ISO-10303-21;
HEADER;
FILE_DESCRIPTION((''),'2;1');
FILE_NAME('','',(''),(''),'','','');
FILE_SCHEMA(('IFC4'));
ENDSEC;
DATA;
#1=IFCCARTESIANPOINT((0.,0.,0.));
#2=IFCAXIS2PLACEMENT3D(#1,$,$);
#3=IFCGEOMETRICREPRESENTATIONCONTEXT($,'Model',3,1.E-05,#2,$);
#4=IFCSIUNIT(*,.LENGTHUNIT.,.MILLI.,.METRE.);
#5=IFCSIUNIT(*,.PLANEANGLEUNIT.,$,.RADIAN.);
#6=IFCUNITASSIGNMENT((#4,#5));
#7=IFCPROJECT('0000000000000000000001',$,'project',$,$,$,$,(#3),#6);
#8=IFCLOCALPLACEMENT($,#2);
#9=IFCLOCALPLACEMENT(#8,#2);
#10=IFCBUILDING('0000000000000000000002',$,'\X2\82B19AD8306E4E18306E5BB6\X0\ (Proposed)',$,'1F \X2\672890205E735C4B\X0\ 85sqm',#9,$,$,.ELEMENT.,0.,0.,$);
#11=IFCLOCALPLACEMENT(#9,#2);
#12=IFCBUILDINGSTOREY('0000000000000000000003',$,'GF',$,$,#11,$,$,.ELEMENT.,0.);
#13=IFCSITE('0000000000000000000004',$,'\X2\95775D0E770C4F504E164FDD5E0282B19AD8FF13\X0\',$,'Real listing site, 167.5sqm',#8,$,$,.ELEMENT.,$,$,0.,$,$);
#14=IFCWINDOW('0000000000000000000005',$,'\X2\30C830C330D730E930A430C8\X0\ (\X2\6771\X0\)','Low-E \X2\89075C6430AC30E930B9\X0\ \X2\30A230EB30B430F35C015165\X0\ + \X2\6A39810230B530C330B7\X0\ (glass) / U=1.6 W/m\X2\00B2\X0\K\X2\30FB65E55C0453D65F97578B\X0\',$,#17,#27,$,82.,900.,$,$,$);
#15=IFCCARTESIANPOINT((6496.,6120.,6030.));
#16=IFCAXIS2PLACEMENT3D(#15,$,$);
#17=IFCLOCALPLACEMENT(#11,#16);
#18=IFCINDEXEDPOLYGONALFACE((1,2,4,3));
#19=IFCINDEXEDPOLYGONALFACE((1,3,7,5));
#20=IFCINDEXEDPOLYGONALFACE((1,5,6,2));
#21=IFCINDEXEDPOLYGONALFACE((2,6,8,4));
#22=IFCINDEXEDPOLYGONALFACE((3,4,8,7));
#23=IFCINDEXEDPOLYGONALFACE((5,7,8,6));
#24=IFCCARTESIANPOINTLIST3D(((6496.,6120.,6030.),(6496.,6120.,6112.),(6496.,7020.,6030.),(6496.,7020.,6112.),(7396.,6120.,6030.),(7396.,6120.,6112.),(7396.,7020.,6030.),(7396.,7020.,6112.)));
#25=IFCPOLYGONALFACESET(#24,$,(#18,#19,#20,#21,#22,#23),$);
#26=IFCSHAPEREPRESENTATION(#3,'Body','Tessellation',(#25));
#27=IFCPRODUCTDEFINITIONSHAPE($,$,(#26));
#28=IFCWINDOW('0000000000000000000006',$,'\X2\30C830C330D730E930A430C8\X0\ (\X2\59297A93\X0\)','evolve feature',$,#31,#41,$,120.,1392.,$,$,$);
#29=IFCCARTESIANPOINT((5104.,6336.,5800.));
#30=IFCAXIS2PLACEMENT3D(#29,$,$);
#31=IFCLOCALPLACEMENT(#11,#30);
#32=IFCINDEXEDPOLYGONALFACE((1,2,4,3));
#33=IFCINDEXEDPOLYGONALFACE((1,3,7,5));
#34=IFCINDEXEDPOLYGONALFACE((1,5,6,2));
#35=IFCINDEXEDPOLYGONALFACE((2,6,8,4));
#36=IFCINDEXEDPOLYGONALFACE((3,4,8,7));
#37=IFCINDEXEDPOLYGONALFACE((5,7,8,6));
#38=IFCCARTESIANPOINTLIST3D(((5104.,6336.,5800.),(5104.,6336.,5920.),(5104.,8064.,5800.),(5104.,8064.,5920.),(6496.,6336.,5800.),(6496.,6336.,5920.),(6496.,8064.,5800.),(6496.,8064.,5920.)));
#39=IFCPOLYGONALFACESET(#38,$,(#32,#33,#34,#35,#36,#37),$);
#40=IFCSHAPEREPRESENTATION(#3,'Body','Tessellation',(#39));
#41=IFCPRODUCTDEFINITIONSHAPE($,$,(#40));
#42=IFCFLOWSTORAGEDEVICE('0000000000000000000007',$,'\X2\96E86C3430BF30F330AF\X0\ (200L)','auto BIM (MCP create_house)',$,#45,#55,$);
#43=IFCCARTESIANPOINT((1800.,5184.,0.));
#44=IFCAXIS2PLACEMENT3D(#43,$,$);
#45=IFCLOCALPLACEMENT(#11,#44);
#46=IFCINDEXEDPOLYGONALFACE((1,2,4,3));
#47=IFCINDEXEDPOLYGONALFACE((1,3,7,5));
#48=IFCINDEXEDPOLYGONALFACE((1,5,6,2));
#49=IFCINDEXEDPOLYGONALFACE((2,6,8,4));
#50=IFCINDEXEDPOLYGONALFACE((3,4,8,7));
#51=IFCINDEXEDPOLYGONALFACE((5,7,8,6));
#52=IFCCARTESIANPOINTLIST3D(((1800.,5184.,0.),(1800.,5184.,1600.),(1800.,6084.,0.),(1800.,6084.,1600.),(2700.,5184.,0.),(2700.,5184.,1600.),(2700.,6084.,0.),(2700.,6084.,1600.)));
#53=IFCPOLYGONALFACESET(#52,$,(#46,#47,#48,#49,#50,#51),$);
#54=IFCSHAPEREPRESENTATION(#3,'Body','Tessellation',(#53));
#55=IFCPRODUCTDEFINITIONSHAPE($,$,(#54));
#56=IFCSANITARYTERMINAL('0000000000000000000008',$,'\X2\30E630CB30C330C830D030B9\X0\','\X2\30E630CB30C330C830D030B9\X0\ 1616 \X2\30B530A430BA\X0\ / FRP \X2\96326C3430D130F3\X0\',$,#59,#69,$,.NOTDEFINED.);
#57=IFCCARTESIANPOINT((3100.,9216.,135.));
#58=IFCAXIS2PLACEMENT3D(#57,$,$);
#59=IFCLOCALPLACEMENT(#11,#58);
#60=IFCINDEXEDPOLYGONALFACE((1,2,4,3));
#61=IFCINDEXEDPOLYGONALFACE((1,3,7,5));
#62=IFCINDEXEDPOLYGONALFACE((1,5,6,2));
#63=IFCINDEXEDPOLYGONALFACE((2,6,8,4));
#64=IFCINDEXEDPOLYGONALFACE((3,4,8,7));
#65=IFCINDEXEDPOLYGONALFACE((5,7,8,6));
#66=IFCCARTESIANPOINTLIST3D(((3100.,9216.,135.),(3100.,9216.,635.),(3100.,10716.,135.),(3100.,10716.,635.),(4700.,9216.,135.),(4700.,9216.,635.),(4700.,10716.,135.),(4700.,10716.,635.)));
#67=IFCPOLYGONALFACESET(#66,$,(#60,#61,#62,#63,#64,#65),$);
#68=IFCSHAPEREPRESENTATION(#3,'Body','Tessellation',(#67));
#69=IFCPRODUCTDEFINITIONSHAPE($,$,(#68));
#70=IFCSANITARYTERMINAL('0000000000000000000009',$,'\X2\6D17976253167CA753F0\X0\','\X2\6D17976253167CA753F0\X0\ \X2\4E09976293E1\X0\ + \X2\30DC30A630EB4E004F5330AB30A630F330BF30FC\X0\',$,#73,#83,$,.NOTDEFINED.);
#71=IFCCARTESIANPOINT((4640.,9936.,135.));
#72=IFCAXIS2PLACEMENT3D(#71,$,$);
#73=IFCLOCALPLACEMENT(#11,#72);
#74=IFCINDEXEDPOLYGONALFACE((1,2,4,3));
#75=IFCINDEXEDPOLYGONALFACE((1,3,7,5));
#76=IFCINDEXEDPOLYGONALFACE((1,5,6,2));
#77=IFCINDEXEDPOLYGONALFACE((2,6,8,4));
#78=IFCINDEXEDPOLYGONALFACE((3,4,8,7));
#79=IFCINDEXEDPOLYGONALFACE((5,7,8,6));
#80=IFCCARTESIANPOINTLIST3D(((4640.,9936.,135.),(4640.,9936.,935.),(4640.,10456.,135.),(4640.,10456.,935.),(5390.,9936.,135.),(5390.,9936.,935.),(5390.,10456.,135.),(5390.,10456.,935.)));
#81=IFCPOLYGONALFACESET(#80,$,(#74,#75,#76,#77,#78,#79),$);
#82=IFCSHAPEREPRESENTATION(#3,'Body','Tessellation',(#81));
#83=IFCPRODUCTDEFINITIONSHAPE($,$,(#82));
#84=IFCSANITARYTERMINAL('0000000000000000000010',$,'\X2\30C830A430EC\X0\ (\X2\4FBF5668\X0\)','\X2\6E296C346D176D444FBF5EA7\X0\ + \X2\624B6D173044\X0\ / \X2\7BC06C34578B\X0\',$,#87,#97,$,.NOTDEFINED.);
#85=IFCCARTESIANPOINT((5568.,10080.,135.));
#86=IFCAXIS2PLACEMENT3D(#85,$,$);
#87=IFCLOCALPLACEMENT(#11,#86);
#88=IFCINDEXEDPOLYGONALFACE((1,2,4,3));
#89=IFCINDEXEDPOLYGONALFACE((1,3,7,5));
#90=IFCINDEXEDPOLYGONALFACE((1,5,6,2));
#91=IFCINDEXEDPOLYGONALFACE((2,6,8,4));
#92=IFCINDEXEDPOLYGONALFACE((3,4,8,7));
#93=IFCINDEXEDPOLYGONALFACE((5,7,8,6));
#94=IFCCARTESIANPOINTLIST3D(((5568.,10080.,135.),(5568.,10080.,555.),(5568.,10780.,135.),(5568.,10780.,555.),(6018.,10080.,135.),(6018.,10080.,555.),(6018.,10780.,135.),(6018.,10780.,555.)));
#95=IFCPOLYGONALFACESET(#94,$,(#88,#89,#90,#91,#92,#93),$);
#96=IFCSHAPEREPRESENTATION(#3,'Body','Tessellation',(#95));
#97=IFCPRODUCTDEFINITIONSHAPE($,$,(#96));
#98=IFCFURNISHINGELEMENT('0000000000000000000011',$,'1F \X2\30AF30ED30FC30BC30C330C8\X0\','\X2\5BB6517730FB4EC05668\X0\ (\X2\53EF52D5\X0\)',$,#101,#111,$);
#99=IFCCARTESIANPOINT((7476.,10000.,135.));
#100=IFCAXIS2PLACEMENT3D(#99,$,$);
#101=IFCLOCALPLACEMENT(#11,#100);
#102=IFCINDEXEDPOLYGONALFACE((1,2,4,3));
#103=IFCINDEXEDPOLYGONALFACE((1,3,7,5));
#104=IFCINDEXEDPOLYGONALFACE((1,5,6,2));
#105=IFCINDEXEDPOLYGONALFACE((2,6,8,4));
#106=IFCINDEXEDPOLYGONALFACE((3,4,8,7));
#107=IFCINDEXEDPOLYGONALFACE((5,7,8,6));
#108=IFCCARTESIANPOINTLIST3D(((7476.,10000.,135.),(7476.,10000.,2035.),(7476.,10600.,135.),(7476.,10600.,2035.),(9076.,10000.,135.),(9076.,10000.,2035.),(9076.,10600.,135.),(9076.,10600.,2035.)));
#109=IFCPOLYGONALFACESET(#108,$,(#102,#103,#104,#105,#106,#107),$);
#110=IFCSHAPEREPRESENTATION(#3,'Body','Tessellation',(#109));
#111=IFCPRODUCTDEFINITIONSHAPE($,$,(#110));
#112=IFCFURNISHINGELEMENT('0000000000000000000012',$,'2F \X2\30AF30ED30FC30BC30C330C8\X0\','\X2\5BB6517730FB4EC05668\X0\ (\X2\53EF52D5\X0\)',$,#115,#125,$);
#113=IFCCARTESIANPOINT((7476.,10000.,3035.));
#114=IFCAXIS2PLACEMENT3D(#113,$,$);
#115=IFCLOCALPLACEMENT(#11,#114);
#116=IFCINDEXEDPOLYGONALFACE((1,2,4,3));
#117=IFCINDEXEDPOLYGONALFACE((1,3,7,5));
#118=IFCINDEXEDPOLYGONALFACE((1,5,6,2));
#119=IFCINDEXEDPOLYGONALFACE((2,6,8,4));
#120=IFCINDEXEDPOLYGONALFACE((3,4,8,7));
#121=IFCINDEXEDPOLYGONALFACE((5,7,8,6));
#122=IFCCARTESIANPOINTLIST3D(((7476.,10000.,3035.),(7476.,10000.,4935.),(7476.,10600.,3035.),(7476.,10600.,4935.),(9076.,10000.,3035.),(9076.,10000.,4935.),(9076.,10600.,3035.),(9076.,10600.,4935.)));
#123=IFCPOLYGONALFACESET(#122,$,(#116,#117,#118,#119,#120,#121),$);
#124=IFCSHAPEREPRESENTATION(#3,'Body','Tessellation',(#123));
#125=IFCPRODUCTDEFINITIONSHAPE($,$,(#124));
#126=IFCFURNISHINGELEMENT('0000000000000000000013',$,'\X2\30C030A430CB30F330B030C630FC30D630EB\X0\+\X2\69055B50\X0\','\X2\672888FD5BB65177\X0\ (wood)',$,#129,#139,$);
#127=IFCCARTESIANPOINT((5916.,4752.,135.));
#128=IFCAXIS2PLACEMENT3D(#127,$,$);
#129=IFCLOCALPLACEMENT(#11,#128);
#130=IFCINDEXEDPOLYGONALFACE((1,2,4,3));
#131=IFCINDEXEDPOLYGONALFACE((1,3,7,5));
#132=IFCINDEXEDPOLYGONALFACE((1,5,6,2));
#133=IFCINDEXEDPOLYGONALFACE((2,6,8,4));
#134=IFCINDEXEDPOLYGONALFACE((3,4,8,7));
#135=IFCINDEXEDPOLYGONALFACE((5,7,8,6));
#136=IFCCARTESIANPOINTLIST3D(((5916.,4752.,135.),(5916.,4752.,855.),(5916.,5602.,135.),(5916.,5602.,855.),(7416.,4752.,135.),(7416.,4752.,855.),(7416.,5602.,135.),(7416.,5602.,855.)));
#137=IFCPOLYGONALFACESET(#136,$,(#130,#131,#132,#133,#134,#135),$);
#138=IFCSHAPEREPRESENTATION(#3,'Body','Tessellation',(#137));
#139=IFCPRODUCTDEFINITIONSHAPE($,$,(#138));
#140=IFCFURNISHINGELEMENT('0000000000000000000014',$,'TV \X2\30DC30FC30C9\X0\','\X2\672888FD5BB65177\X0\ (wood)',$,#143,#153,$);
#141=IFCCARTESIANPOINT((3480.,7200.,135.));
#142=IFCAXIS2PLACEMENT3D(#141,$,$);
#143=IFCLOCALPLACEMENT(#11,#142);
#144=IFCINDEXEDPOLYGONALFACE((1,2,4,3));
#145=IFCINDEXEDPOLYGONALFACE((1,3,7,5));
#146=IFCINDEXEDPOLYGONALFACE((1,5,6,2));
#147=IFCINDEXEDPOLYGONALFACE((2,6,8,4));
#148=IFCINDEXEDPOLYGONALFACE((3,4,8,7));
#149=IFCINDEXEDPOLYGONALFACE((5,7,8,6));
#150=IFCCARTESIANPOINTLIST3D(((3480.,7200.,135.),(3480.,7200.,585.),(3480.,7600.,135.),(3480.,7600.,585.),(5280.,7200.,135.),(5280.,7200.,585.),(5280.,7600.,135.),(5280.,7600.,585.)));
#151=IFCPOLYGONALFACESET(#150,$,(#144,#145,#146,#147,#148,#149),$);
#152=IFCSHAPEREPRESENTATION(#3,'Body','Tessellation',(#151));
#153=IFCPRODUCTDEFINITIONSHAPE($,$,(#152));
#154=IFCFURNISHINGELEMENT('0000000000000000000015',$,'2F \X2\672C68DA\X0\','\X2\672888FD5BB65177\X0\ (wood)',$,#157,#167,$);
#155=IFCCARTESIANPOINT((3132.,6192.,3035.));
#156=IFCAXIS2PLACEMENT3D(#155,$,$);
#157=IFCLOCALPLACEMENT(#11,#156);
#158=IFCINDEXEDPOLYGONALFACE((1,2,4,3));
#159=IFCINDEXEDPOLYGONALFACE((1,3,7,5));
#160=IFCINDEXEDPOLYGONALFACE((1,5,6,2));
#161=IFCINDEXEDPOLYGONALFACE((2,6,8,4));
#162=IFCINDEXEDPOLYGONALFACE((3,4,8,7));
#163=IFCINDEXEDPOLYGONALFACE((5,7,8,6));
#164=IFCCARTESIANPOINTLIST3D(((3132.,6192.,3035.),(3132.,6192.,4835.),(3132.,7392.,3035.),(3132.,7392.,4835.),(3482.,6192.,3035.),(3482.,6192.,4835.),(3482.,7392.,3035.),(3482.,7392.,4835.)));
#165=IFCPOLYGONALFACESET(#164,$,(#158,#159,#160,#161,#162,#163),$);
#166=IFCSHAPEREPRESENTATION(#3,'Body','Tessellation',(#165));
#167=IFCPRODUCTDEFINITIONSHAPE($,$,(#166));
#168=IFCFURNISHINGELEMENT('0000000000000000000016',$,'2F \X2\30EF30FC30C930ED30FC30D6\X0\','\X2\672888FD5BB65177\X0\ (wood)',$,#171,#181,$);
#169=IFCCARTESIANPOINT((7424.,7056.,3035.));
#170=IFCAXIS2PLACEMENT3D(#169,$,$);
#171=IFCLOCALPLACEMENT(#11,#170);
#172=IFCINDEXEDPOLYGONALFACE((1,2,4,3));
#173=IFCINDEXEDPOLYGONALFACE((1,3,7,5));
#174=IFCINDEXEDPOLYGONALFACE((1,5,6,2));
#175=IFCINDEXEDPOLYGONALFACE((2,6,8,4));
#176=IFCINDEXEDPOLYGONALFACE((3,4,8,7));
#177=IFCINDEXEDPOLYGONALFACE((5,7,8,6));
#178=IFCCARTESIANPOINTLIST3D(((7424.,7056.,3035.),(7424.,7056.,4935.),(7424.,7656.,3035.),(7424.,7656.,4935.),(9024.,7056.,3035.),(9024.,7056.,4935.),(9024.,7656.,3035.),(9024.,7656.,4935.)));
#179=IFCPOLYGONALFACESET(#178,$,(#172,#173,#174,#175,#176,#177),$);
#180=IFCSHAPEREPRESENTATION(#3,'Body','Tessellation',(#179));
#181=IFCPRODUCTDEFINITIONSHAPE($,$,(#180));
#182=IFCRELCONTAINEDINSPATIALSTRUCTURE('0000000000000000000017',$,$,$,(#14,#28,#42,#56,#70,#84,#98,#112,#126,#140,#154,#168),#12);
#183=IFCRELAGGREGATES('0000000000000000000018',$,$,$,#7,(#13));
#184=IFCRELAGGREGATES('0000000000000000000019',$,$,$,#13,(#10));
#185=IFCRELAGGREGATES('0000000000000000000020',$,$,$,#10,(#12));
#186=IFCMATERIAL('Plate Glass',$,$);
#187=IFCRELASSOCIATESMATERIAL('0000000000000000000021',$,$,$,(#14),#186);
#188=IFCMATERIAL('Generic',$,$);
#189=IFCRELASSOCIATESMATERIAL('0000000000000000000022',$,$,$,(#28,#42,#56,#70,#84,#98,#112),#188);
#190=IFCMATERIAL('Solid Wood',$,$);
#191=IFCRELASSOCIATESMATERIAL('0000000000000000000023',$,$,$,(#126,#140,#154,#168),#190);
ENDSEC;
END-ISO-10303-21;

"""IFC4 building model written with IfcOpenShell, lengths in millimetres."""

from ifc_helpers import new_model, si_unit, frame, frame_2d, origin, place, context, project, spatial, rectangle, extrude, material, element, save


model = new_model("IFC4")

# Units and contexts
model_context = context("Model", 3, precision=1e-05, world=origin())
ifc_project = project(units=[si_unit("LENGTHUNIT", "METRE", prefix="MILLI"), si_unit("PLANEANGLEUNIT", "RADIAN")], contexts=[model_context])

# Site, building, storey
site_placement = place(None, origin())
site = spatial("IfcSite", under=ifc_project, at=site_placement, Name="長崎県佐世保市花高３", ObjectType="Real listing site, 167.5sqm", CompositionType="ELEMENT", RefElevation=0.0)
building_placement = place(site_placement, origin())
building = spatial("IfcBuilding", under=site, at=building_placement, Name="花高の丘の家 (Proposed)", ObjectType="1F 木造平屋 85sqm", CompositionType="ELEMENT", ElevationOfRefHeight=0.0, ElevationOfTerrain=0.0)
storey_placement = place(building_placement, origin())
storey = spatial("IfcBuildingStorey", under=building, at=storey_placement, Name="GF", CompositionType="ELEMENT", Elevation=0.0)

# Shared definitions
ifc_material_1 = material(Name="Solid Wood")
ifc_material_2 = material(Name="Plate Glass")

# Windows
window_1_placement = place(storey_placement, frame((6496.0, 6120.0, 6030.0)))
element("IfcWindow", 1, at=window_1_placement, inside=storey, material=ifc_material_2, Name="トップライト (東)", Description="Low-E 複層ガラス アルゴン封入 + 樹脂サッシ (glass) / U=1.6 W/m²K・日射取得型", OverallHeight=82.0, OverallWidth=900.0, context=model_context, shape_type="SweptSolid", body=[
    extrude(rectangle(XDim=900.0, YDim=900.0, at=frame_2d((450.0, 450.0))), frame((6496.0, 6120.0, 6030.0)), (0.0, 0.0, 1.0), 82.0),
])
ifc_material_3 = material(Name="Generic")
window_2_placement = place(storey_placement, frame((5104.0, 6336.0, 5800.0)))
element("IfcWindow", 2, at=window_2_placement, inside=storey, material=ifc_material_3, Name="トップライト (天窓)", Description="evolve feature", OverallHeight=120.0, OverallWidth=1392.0, context=model_context, shape_type="SweptSolid", body=[
    extrude(rectangle(XDim=1392.0, YDim=1728.0, at=frame_2d((696.0, 864.0))), frame((5104.0, 6336.0, 5800.0)), (0.0, 0.0, 1.0), 120.0),
])

# Flow storage device
flow_storage_device_placement = place(storey_placement, frame((1800.0, 5184.0, 0.0)))
element("IfcFlowStorageDevice", 3, at=flow_storage_device_placement, inside=storey, material=ifc_material_3, Name="雨水タンク (200L)", Description="auto BIM (MCP create_house)", context=model_context, shape_type="SweptSolid", body=[
    extrude(rectangle(XDim=900.0, YDim=900.0, at=frame_2d((450.0, 450.0))), frame((1800.0, 5184.0, 0.0)), (0.0, 0.0, 1.0), 1600.0),
])

# Sanitary terminals
sanitary_terminal_1_placement = place(storey_placement, frame((3100.0, 9216.0, 135.0)))
element("IfcSanitaryTerminal", 4, at=sanitary_terminal_1_placement, inside=storey, material=ifc_material_3, Name="ユニットバス", Description="ユニットバス 1616 サイズ / FRP 防水パン", PredefinedType="NOTDEFINED", context=model_context, shape_type="SweptSolid", body=[
    extrude(rectangle(XDim=1600.0, YDim=1500.0, at=frame_2d((800.0, 750.0))), frame((3100.0, 9216.0, 135.0)), (0.0, 0.0, 1.0), 500.0),
])
sanitary_terminal_2_placement = place(storey_placement, frame((4640.0, 9936.0, 135.0)))
element("IfcSanitaryTerminal", 5, at=sanitary_terminal_2_placement, inside=storey, material=ifc_material_3, Name="洗面化粧台", Description="洗面化粧台 三面鏡 + ボウル一体カウンター", PredefinedType="NOTDEFINED", context=model_context, shape_type="SweptSolid", body=[
    extrude(rectangle(XDim=750.0, YDim=520.0, at=frame_2d((375.0, 260.0))), frame((4640.0, 9936.0, 135.0)), (0.0, 0.0, 1.0), 800.0),
])
sanitary_terminal_3_placement = place(storey_placement, frame((5568.0, 10080.0, 135.0)))
element("IfcSanitaryTerminal", 6, at=sanitary_terminal_3_placement, inside=storey, material=ifc_material_3, Name="トイレ (便器)", Description="温水洗浄便座 + 手洗い / 節水型", PredefinedType="NOTDEFINED", context=model_context, shape_type="SweptSolid", body=[
    extrude(rectangle(XDim=450.0, YDim=700.0, at=frame_2d((225.0, 350.0))), frame((5568.0, 10080.0, 135.0)), (0.0, 0.0, 1.0), 420.0),
])

# Furnishing elements
furnishing_1_placement = place(storey_placement, frame((7476.0, 10000.0, 135.0)))
element("IfcFurnishingElement", 7, at=furnishing_1_placement, inside=storey, material=ifc_material_3, Name="1F クローゼット", Description="家具・什器 (可動)", context=model_context, shape_type="SweptSolid", body=[
    extrude(rectangle(XDim=1600.0, YDim=600.0, at=frame_2d((800.0, 300.0))), frame((7476.0, 10000.0, 135.0)), (0.0, 0.0, 1.0), 1900.0),
])
furnishing_2_placement = place(storey_placement, frame((7476.0, 10000.0, 3035.0)))
element("IfcFurnishingElement", 8, at=furnishing_2_placement, inside=storey, material=ifc_material_3, Name="2F クローゼット", Description="家具・什器 (可動)", context=model_context, shape_type="SweptSolid", body=[
    extrude(rectangle(XDim=1600.0, YDim=600.0, at=frame_2d((800.0, 300.0))), frame((7476.0, 10000.0, 3035.0)), (0.0, 0.0, 1.0), 1900.0),
])
furnishing_3_placement = place(storey_placement, frame((5916.0, 4752.0, 135.0)))
element("IfcFurnishingElement", 9, at=furnishing_3_placement, inside=storey, material=ifc_material_1, Name="ダイニングテーブル+椅子", Description="木製家具 (wood)", context=model_context, shape_type="SweptSolid", body=[
    extrude(rectangle(XDim=1500.0, YDim=850.0, at=frame_2d((750.0, 425.0))), frame((5916.0, 4752.0, 135.0)), (0.0, 0.0, 1.0), 720.0),
])
furnishing_4_placement = place(storey_placement, frame((3480.0, 7200.0, 135.0)))
element("IfcFurnishingElement", 10, at=furnishing_4_placement, inside=storey, material=ifc_material_1, Name="TV ボード", Description="木製家具 (wood)", context=model_context, shape_type="SweptSolid", body=[
    extrude(rectangle(XDim=1800.0, YDim=400.0, at=frame_2d((900.0, 200.0))), frame((3480.0, 7200.0, 135.0)), (0.0, 0.0, 1.0), 450.0),
])
furnishing_5_placement = place(storey_placement, frame((3132.0, 6192.0, 3035.0)))
element("IfcFurnishingElement", 11, at=furnishing_5_placement, inside=storey, material=ifc_material_1, Name="2F 本棚", Description="木製家具 (wood)", context=model_context, shape_type="SweptSolid", body=[
    extrude(rectangle(XDim=350.0, YDim=1200.0, at=frame_2d((175.0, 600.0))), frame((3132.0, 6192.0, 3035.0)), (0.0, 0.0, 1.0), 1800.0),
])
furnishing_6_placement = place(storey_placement, frame((7424.0, 7056.0, 3035.0)))
element("IfcFurnishingElement", 12, at=furnishing_6_placement, inside=storey, material=ifc_material_1, Name="2F ワードローブ", Description="木製家具 (wood)", context=model_context, shape_type="SweptSolid", body=[
    extrude(rectangle(XDim=1600.0, YDim=600.0, at=frame_2d((800.0, 300.0))), frame((7424.0, 7056.0, 3035.0)), (0.0, 0.0, 1.0), 1900.0),
])

save(model, "model.ifc")
